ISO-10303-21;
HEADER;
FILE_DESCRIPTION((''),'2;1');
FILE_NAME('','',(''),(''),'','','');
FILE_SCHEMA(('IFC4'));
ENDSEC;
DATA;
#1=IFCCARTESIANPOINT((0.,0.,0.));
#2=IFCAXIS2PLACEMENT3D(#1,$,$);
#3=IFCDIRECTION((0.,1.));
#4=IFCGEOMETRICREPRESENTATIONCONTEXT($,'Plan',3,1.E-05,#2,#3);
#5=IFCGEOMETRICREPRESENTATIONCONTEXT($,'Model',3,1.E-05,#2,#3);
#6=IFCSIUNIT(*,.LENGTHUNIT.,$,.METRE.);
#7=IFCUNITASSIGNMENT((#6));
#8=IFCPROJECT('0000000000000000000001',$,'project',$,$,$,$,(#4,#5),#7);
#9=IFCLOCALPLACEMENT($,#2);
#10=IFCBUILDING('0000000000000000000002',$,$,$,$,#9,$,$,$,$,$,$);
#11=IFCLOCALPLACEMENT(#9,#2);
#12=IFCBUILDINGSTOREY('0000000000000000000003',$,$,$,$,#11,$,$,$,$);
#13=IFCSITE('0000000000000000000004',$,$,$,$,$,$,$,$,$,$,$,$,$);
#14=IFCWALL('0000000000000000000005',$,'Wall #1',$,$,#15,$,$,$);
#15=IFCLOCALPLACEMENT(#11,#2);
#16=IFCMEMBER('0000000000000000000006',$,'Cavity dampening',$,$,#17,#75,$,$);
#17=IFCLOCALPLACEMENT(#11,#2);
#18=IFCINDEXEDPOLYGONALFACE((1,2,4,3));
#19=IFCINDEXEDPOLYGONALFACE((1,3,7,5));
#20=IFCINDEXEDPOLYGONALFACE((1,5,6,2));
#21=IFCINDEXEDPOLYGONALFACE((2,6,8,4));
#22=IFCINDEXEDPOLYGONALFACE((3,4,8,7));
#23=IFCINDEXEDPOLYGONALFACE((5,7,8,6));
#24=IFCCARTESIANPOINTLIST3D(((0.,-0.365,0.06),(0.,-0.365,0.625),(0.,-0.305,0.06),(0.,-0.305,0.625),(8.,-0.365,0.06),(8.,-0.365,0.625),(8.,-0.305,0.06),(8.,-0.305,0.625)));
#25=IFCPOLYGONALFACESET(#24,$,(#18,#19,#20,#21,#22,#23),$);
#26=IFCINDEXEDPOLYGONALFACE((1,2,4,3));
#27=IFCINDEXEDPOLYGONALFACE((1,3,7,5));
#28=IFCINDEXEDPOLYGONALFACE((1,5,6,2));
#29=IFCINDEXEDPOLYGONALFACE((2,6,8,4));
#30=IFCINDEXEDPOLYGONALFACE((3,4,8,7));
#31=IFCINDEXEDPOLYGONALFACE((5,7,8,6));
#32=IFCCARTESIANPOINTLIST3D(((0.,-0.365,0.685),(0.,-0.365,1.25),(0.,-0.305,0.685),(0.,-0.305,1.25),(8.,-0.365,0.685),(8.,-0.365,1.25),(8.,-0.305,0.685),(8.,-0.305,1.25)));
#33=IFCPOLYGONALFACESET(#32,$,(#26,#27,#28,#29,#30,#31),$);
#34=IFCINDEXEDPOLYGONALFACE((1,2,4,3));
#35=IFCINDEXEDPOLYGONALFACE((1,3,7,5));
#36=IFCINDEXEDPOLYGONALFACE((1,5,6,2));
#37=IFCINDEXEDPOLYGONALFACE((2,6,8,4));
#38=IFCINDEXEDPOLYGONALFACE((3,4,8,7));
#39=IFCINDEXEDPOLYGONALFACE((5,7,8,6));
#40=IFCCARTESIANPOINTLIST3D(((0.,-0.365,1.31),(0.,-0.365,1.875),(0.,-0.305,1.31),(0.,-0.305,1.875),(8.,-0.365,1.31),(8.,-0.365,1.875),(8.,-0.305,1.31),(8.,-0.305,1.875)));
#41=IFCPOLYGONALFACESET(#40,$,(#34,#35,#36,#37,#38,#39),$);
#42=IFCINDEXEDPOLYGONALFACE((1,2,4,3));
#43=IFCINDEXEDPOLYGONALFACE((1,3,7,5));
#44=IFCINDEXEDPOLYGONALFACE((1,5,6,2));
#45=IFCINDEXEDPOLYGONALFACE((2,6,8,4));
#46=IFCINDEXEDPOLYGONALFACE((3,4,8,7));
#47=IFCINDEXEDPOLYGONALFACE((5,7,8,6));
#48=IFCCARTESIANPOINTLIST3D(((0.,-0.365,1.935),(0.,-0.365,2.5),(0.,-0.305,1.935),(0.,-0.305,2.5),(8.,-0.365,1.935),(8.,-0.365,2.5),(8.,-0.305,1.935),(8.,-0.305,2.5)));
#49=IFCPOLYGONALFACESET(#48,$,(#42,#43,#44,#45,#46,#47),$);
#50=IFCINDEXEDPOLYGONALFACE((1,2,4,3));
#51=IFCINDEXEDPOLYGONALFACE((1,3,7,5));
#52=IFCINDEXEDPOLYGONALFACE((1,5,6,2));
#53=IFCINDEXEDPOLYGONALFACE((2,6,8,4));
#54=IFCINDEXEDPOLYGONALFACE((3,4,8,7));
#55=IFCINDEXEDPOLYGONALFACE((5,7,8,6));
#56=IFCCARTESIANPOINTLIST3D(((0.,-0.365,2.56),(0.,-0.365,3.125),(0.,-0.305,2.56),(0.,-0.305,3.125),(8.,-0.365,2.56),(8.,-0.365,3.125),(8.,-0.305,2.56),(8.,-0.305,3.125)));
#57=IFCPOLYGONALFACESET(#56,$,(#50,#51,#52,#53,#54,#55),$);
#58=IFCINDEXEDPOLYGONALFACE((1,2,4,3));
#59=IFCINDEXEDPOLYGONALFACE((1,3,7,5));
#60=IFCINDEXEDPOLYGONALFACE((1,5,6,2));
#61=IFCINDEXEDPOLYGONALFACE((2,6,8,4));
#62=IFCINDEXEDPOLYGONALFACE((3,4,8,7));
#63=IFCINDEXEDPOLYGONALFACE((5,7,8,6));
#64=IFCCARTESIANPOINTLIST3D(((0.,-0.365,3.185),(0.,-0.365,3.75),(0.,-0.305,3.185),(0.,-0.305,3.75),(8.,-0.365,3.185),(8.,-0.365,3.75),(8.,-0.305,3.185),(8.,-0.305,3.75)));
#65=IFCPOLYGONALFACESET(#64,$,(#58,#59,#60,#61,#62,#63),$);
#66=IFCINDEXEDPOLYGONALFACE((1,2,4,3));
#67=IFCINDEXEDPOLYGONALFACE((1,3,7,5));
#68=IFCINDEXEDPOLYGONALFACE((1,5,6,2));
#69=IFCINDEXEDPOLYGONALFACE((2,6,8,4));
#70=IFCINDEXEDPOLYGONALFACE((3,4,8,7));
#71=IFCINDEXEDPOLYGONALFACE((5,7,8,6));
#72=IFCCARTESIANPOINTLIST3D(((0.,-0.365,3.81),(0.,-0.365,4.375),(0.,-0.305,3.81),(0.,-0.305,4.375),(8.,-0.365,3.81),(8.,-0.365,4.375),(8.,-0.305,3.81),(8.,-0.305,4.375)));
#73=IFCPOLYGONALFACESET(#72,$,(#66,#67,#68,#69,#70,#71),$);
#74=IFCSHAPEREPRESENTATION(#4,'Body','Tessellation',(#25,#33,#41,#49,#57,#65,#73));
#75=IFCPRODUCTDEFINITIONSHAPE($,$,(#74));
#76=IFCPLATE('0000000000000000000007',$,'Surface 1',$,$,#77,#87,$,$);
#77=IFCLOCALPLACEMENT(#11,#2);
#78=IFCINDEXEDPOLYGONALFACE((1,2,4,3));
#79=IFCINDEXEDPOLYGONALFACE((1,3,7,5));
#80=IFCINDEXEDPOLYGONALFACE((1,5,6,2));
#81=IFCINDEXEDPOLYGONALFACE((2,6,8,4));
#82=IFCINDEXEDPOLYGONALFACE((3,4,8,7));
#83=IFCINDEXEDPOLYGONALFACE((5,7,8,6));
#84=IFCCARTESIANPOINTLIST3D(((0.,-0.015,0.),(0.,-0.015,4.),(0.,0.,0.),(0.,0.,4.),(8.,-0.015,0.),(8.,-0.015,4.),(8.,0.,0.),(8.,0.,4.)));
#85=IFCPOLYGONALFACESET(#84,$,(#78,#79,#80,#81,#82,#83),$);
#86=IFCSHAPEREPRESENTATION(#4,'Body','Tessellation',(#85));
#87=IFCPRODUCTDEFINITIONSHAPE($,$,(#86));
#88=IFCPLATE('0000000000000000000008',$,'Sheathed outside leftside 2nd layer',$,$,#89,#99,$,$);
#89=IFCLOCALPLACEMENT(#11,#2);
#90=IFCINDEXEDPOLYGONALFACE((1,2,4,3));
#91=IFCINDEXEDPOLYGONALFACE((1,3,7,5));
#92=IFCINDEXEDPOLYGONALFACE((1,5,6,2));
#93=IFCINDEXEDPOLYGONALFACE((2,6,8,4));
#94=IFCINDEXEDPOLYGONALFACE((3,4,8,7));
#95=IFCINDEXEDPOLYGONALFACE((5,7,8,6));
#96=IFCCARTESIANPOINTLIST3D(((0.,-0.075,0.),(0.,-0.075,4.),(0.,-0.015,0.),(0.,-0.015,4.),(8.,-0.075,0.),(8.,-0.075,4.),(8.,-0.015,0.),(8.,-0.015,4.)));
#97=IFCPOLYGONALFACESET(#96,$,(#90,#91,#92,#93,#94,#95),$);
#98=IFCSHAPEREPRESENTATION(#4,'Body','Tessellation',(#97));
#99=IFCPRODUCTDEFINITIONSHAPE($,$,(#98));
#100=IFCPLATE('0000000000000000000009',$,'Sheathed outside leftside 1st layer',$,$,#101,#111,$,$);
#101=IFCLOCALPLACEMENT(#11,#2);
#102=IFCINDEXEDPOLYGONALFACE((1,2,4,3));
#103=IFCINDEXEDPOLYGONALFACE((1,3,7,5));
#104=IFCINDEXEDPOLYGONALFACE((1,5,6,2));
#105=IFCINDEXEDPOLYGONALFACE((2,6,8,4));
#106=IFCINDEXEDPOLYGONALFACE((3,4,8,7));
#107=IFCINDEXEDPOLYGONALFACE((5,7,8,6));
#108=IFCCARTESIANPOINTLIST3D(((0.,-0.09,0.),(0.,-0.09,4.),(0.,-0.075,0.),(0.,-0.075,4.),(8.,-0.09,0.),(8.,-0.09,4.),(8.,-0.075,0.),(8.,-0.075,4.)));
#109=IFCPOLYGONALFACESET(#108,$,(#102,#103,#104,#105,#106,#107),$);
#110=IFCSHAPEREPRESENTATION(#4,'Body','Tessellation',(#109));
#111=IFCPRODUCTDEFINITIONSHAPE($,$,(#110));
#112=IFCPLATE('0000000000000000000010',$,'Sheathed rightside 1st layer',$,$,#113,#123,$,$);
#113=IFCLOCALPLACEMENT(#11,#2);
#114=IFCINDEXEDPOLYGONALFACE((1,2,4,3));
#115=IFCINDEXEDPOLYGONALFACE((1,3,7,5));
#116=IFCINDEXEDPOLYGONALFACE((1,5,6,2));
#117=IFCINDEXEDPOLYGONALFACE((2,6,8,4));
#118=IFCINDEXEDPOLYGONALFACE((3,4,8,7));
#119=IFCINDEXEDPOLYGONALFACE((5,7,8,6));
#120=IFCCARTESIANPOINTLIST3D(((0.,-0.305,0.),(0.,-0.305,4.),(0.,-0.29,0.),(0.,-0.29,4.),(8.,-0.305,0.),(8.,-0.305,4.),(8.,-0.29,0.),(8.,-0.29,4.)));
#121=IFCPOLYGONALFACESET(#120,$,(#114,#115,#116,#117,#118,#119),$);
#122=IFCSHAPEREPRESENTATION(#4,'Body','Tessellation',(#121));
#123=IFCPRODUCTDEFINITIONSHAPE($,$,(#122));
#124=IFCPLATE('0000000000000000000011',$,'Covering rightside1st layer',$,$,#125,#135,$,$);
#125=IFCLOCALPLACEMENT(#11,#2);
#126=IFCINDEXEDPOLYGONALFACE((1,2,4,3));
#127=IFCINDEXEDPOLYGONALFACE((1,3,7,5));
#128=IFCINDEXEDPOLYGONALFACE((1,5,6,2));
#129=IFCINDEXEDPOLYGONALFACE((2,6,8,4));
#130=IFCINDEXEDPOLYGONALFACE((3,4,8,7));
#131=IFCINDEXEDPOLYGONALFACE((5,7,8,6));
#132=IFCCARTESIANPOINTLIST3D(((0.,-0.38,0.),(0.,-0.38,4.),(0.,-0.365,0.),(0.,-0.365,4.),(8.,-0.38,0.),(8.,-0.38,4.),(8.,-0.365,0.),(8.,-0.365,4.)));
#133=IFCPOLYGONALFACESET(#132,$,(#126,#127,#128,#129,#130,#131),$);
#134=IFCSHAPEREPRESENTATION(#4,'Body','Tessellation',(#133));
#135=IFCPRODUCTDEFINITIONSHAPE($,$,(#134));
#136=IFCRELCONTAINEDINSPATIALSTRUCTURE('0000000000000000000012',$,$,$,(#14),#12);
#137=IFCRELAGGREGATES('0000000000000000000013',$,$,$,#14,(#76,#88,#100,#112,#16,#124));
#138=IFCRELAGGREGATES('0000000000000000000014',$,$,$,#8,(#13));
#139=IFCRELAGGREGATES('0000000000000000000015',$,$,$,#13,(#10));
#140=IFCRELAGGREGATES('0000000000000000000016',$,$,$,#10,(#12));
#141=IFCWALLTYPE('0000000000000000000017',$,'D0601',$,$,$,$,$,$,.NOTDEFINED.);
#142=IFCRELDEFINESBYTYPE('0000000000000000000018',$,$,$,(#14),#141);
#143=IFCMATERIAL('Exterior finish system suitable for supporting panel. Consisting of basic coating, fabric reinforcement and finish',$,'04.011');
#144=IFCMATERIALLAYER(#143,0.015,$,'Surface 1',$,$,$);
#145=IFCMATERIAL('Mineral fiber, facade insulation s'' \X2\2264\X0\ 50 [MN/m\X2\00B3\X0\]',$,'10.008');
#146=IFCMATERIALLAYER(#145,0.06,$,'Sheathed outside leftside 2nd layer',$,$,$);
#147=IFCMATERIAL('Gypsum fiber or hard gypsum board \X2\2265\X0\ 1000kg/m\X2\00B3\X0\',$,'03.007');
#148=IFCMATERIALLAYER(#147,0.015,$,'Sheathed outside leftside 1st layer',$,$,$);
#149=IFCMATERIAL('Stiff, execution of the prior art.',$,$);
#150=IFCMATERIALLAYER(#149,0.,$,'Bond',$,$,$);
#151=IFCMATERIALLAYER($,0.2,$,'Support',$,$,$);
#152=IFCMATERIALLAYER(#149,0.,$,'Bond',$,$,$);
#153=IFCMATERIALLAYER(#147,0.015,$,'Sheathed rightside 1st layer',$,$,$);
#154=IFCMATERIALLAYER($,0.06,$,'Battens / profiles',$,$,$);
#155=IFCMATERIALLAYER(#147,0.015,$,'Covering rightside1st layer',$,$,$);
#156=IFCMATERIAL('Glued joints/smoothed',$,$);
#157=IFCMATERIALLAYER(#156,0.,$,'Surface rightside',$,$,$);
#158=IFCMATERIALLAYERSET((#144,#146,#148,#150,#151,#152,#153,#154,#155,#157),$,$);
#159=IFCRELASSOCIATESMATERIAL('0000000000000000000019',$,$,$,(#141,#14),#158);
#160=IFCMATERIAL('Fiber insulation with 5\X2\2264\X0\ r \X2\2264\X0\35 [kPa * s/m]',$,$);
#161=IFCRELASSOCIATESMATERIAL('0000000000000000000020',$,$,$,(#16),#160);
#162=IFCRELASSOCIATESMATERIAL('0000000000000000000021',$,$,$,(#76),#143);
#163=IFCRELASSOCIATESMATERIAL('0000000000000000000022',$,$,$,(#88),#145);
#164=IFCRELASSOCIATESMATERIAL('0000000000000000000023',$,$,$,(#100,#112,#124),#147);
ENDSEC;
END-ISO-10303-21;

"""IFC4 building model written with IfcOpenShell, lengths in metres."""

from ifc_helpers import new_model, si_unit, direction, frame, frame_2d, origin, origin_with_axes, place, context, project, spatial, rectangle, extrude, material, layer, layer_set, type_object, element, aggregate, save


model = new_model("IFC4")

# Units and contexts
plan_context = context("Plan", 3, precision=1e-05, world=origin(), true_north=direction((0.0, 1.0)))
model_context = context("Model", 3, precision=1e-05, world=origin(), true_north=direction((0.0, 1.0)))
ifc_project = project(units=[si_unit("LENGTHUNIT", "METRE")], contexts=[plan_context, model_context])

# Site, building, storey
site = spatial("IfcSite", under=ifc_project)
building_placement = place(None, origin())
building = spatial("IfcBuilding", under=site, at=building_placement)
storey_placement = place(building_placement, origin())
storey = spatial("IfcBuildingStorey", under=building, at=storey_placement)

# Wall, member, plates
ifc_material_1 = material(Name="Exterior finish system suitable for supporting panel. Consisting of basic coating, fabric reinforcement and finish", Category="04.011")
ifc_layer_1 = layer(ifc_material_1, 0.015, Name="Surface 1")
ifc_material_2 = material(Name="Mineral fiber, facade insulation s' ≤ 50 [MN/m³]", Category="10.008")
ifc_layer_2 = layer(ifc_material_2, 0.06, Name="Sheathed outside leftside 2nd layer")
ifc_material_3 = material(Name="Gypsum fiber or hard gypsum board ≥ 1000kg/m³", Category="03.007")
ifc_layer_3 = layer(ifc_material_3, 0.015, Name="Sheathed outside leftside 1st layer")
ifc_material_4 = material(Name="Stiff, execution of the prior art.")
ifc_layer_4 = layer(ifc_material_4, 0.0, Name="Bond")
ifc_layer_5 = layer(None, 0.2, Name="Support")
ifc_layer_6 = layer(ifc_material_4, 0.0, Name="Bond")
ifc_layer_7 = layer(ifc_material_3, 0.015, Name="Sheathed rightside 1st layer")
ifc_layer_8 = layer(None, 0.06, Name="Battens / profiles")
ifc_layer_9 = layer(ifc_material_3, 0.015, Name="Covering rightside1st layer")
ifc_material_5 = material(Name="Glued joints/smoothed")
ifc_layer_10 = layer(ifc_material_5, 0.0, Name="Surface rightside")
ifc_layer_set = layer_set([ifc_layer_1, ifc_layer_2, ifc_layer_3, ifc_layer_4, ifc_layer_5, ifc_layer_6, ifc_layer_7, ifc_layer_8, ifc_layer_9, ifc_layer_10])
wall_type = type_object("IfcWallType", Name="D0601", PredefinedType="NOTDEFINED", material=ifc_layer_set)
wall_placement = place(None, frame((0.0, 0.0, 0.0), z_axis=(0.0, -1.0, 0.0), x_axis=(1.0, 0.0, 0.0)))
wall = element("IfcWall", 1, at=wall_placement, inside=storey, type_object=wall_type, material=ifc_layer_set, Name="Wall #1")
ifc_material_6 = material(Name="Fiber insulation with 5≤ r ≤35 [kPa * s/m]")
member_1_placement = place(wall_placement, origin())
member_1 = element("IfcMember", 2, at=member_1_placement, material=ifc_material_6, Name="Cavity dampening", context=plan_context, shape_type="SweptSolid", body=[
    extrude(rectangle(XDim=0.565, YDim=0.06, at=frame_2d((0.2825, 0.03), x_axis=(1.0, 0.0))), frame((0.0, 0.06, 0.305), z_axis=(1.0, 0.0, 0.0), x_axis=(0.0, 1.0, 0.0)), (0.0, 0.0, 1.0), 8.0),
    extrude(rectangle(XDim=0.565, YDim=0.06, at=frame_2d((0.2825, 0.03), x_axis=(1.0, 0.0))), frame((0.0, 0.685, 0.305), z_axis=(1.0, 0.0, 0.0), x_axis=(0.0, 1.0, 0.0)), (0.0, 0.0, 1.0), 8.0),
    extrude(rectangle(XDim=0.565, YDim=0.06, at=frame_2d((0.2825, 0.03), x_axis=(1.0, 0.0))), frame((0.0, 1.31, 0.305), z_axis=(1.0, 0.0, 0.0), x_axis=(0.0, 1.0, 0.0)), (0.0, 0.0, 1.0), 8.0),
    extrude(rectangle(XDim=0.565, YDim=0.06, at=frame_2d((0.2825, 0.03), x_axis=(1.0, 0.0))), frame((0.0, 1.935, 0.305), z_axis=(1.0, 0.0, 0.0), x_axis=(0.0, 1.0, 0.0)), (0.0, 0.0, 1.0), 8.0),
    extrude(rectangle(XDim=0.565, YDim=0.06, at=frame_2d((0.2825, 0.03), x_axis=(1.0, 0.0))), frame((0.0, 2.56, 0.305), z_axis=(1.0, 0.0, 0.0), x_axis=(0.0, 1.0, 0.0)), (0.0, 0.0, 1.0), 8.0),
    extrude(rectangle(XDim=0.565, YDim=0.06, at=frame_2d((0.2825, 0.03), x_axis=(1.0, 0.0))), frame((0.0, 3.185, 0.305), z_axis=(1.0, 0.0, 0.0), x_axis=(0.0, 1.0, 0.0)), (0.0, 0.0, 1.0), 8.0),
    extrude(rectangle(XDim=0.565, YDim=0.06, at=frame_2d((0.2825, 0.03), x_axis=(1.0, 0.0))), frame((0.0, 3.81, 0.305), z_axis=(1.0, 0.0, 0.0), x_axis=(0.0, 1.0, 0.0)), (0.0, 0.0, 1.0), 8.0),
])
plate_1_placement = place(wall_placement, origin())
plate_1 = element("IfcPlate", 3, at=plate_1_placement, material=ifc_material_1, Name="Surface 1", context=plan_context, shape_type="SweptSolid", body=[
    extrude(rectangle(XDim=8.0, YDim=4.0, at=frame_2d((4.0, 2.0), x_axis=(1.0, 0.0))), origin_with_axes(), (0.0, 0.0, 1.0), 0.015),
])
plate_2_placement = place(wall_placement, origin())
plate_2 = element("IfcPlate", 4, at=plate_2_placement, material=ifc_material_2, Name="Sheathed outside leftside 2nd layer", context=plan_context, shape_type="SweptSolid", body=[
    extrude(rectangle(XDim=8.0, YDim=4.0, at=frame_2d((4.0, 2.0), x_axis=(1.0, 0.0))), frame((0.0, 0.0, 0.015), z_axis=(0.0, 0.0, 1.0), x_axis=(1.0, 0.0, 0.0)), (0.0, 0.0, 1.0), 0.06),
])
plate_3_placement = place(wall_placement, origin())
plate_3 = element("IfcPlate", 5, at=plate_3_placement, material=ifc_material_3, Name="Sheathed outside leftside 1st layer", context=plan_context, shape_type="SweptSolid", body=[
    extrude(rectangle(XDim=8.0, YDim=4.0, at=frame_2d((4.0, 2.0), x_axis=(1.0, 0.0))), frame((0.0, 0.0, 0.075), z_axis=(0.0, 0.0, 1.0), x_axis=(1.0, 0.0, 0.0)), (0.0, 0.0, 1.0), 0.015),
])
plate_4_placement = place(wall_placement, origin())
plate_4 = element("IfcPlate", 6, at=plate_4_placement, material=ifc_material_3, Name="Sheathed rightside 1st layer", context=plan_context, shape_type="SweptSolid", body=[
    extrude(rectangle(XDim=8.0, YDim=4.0, at=frame_2d((4.0, 2.0), x_axis=(1.0, 0.0))), frame((0.0, 0.0, 0.29), z_axis=(0.0, 0.0, 1.0), x_axis=(1.0, 0.0, 0.0)), (0.0, 0.0, 1.0), 0.015),
])
plate_5_placement = place(wall_placement, origin())
plate_5 = element("IfcPlate", 7, at=plate_5_placement, material=ifc_material_3, Name="Covering rightside1st layer", context=plan_context, shape_type="SweptSolid", body=[
    extrude(rectangle(XDim=8.0, YDim=4.0, at=frame_2d((4.0, 2.0), x_axis=(1.0, 0.0))), frame((0.0, 0.0, 0.365), z_axis=(0.0, 0.0, 1.0), x_axis=(1.0, 0.0, 0.0)), (0.0, 0.0, 1.0), 0.015),
])
aggregate(wall, [plate_1, plate_2, plate_3, plate_4, member_1, plate_5])

save(model, "model.ifc")
